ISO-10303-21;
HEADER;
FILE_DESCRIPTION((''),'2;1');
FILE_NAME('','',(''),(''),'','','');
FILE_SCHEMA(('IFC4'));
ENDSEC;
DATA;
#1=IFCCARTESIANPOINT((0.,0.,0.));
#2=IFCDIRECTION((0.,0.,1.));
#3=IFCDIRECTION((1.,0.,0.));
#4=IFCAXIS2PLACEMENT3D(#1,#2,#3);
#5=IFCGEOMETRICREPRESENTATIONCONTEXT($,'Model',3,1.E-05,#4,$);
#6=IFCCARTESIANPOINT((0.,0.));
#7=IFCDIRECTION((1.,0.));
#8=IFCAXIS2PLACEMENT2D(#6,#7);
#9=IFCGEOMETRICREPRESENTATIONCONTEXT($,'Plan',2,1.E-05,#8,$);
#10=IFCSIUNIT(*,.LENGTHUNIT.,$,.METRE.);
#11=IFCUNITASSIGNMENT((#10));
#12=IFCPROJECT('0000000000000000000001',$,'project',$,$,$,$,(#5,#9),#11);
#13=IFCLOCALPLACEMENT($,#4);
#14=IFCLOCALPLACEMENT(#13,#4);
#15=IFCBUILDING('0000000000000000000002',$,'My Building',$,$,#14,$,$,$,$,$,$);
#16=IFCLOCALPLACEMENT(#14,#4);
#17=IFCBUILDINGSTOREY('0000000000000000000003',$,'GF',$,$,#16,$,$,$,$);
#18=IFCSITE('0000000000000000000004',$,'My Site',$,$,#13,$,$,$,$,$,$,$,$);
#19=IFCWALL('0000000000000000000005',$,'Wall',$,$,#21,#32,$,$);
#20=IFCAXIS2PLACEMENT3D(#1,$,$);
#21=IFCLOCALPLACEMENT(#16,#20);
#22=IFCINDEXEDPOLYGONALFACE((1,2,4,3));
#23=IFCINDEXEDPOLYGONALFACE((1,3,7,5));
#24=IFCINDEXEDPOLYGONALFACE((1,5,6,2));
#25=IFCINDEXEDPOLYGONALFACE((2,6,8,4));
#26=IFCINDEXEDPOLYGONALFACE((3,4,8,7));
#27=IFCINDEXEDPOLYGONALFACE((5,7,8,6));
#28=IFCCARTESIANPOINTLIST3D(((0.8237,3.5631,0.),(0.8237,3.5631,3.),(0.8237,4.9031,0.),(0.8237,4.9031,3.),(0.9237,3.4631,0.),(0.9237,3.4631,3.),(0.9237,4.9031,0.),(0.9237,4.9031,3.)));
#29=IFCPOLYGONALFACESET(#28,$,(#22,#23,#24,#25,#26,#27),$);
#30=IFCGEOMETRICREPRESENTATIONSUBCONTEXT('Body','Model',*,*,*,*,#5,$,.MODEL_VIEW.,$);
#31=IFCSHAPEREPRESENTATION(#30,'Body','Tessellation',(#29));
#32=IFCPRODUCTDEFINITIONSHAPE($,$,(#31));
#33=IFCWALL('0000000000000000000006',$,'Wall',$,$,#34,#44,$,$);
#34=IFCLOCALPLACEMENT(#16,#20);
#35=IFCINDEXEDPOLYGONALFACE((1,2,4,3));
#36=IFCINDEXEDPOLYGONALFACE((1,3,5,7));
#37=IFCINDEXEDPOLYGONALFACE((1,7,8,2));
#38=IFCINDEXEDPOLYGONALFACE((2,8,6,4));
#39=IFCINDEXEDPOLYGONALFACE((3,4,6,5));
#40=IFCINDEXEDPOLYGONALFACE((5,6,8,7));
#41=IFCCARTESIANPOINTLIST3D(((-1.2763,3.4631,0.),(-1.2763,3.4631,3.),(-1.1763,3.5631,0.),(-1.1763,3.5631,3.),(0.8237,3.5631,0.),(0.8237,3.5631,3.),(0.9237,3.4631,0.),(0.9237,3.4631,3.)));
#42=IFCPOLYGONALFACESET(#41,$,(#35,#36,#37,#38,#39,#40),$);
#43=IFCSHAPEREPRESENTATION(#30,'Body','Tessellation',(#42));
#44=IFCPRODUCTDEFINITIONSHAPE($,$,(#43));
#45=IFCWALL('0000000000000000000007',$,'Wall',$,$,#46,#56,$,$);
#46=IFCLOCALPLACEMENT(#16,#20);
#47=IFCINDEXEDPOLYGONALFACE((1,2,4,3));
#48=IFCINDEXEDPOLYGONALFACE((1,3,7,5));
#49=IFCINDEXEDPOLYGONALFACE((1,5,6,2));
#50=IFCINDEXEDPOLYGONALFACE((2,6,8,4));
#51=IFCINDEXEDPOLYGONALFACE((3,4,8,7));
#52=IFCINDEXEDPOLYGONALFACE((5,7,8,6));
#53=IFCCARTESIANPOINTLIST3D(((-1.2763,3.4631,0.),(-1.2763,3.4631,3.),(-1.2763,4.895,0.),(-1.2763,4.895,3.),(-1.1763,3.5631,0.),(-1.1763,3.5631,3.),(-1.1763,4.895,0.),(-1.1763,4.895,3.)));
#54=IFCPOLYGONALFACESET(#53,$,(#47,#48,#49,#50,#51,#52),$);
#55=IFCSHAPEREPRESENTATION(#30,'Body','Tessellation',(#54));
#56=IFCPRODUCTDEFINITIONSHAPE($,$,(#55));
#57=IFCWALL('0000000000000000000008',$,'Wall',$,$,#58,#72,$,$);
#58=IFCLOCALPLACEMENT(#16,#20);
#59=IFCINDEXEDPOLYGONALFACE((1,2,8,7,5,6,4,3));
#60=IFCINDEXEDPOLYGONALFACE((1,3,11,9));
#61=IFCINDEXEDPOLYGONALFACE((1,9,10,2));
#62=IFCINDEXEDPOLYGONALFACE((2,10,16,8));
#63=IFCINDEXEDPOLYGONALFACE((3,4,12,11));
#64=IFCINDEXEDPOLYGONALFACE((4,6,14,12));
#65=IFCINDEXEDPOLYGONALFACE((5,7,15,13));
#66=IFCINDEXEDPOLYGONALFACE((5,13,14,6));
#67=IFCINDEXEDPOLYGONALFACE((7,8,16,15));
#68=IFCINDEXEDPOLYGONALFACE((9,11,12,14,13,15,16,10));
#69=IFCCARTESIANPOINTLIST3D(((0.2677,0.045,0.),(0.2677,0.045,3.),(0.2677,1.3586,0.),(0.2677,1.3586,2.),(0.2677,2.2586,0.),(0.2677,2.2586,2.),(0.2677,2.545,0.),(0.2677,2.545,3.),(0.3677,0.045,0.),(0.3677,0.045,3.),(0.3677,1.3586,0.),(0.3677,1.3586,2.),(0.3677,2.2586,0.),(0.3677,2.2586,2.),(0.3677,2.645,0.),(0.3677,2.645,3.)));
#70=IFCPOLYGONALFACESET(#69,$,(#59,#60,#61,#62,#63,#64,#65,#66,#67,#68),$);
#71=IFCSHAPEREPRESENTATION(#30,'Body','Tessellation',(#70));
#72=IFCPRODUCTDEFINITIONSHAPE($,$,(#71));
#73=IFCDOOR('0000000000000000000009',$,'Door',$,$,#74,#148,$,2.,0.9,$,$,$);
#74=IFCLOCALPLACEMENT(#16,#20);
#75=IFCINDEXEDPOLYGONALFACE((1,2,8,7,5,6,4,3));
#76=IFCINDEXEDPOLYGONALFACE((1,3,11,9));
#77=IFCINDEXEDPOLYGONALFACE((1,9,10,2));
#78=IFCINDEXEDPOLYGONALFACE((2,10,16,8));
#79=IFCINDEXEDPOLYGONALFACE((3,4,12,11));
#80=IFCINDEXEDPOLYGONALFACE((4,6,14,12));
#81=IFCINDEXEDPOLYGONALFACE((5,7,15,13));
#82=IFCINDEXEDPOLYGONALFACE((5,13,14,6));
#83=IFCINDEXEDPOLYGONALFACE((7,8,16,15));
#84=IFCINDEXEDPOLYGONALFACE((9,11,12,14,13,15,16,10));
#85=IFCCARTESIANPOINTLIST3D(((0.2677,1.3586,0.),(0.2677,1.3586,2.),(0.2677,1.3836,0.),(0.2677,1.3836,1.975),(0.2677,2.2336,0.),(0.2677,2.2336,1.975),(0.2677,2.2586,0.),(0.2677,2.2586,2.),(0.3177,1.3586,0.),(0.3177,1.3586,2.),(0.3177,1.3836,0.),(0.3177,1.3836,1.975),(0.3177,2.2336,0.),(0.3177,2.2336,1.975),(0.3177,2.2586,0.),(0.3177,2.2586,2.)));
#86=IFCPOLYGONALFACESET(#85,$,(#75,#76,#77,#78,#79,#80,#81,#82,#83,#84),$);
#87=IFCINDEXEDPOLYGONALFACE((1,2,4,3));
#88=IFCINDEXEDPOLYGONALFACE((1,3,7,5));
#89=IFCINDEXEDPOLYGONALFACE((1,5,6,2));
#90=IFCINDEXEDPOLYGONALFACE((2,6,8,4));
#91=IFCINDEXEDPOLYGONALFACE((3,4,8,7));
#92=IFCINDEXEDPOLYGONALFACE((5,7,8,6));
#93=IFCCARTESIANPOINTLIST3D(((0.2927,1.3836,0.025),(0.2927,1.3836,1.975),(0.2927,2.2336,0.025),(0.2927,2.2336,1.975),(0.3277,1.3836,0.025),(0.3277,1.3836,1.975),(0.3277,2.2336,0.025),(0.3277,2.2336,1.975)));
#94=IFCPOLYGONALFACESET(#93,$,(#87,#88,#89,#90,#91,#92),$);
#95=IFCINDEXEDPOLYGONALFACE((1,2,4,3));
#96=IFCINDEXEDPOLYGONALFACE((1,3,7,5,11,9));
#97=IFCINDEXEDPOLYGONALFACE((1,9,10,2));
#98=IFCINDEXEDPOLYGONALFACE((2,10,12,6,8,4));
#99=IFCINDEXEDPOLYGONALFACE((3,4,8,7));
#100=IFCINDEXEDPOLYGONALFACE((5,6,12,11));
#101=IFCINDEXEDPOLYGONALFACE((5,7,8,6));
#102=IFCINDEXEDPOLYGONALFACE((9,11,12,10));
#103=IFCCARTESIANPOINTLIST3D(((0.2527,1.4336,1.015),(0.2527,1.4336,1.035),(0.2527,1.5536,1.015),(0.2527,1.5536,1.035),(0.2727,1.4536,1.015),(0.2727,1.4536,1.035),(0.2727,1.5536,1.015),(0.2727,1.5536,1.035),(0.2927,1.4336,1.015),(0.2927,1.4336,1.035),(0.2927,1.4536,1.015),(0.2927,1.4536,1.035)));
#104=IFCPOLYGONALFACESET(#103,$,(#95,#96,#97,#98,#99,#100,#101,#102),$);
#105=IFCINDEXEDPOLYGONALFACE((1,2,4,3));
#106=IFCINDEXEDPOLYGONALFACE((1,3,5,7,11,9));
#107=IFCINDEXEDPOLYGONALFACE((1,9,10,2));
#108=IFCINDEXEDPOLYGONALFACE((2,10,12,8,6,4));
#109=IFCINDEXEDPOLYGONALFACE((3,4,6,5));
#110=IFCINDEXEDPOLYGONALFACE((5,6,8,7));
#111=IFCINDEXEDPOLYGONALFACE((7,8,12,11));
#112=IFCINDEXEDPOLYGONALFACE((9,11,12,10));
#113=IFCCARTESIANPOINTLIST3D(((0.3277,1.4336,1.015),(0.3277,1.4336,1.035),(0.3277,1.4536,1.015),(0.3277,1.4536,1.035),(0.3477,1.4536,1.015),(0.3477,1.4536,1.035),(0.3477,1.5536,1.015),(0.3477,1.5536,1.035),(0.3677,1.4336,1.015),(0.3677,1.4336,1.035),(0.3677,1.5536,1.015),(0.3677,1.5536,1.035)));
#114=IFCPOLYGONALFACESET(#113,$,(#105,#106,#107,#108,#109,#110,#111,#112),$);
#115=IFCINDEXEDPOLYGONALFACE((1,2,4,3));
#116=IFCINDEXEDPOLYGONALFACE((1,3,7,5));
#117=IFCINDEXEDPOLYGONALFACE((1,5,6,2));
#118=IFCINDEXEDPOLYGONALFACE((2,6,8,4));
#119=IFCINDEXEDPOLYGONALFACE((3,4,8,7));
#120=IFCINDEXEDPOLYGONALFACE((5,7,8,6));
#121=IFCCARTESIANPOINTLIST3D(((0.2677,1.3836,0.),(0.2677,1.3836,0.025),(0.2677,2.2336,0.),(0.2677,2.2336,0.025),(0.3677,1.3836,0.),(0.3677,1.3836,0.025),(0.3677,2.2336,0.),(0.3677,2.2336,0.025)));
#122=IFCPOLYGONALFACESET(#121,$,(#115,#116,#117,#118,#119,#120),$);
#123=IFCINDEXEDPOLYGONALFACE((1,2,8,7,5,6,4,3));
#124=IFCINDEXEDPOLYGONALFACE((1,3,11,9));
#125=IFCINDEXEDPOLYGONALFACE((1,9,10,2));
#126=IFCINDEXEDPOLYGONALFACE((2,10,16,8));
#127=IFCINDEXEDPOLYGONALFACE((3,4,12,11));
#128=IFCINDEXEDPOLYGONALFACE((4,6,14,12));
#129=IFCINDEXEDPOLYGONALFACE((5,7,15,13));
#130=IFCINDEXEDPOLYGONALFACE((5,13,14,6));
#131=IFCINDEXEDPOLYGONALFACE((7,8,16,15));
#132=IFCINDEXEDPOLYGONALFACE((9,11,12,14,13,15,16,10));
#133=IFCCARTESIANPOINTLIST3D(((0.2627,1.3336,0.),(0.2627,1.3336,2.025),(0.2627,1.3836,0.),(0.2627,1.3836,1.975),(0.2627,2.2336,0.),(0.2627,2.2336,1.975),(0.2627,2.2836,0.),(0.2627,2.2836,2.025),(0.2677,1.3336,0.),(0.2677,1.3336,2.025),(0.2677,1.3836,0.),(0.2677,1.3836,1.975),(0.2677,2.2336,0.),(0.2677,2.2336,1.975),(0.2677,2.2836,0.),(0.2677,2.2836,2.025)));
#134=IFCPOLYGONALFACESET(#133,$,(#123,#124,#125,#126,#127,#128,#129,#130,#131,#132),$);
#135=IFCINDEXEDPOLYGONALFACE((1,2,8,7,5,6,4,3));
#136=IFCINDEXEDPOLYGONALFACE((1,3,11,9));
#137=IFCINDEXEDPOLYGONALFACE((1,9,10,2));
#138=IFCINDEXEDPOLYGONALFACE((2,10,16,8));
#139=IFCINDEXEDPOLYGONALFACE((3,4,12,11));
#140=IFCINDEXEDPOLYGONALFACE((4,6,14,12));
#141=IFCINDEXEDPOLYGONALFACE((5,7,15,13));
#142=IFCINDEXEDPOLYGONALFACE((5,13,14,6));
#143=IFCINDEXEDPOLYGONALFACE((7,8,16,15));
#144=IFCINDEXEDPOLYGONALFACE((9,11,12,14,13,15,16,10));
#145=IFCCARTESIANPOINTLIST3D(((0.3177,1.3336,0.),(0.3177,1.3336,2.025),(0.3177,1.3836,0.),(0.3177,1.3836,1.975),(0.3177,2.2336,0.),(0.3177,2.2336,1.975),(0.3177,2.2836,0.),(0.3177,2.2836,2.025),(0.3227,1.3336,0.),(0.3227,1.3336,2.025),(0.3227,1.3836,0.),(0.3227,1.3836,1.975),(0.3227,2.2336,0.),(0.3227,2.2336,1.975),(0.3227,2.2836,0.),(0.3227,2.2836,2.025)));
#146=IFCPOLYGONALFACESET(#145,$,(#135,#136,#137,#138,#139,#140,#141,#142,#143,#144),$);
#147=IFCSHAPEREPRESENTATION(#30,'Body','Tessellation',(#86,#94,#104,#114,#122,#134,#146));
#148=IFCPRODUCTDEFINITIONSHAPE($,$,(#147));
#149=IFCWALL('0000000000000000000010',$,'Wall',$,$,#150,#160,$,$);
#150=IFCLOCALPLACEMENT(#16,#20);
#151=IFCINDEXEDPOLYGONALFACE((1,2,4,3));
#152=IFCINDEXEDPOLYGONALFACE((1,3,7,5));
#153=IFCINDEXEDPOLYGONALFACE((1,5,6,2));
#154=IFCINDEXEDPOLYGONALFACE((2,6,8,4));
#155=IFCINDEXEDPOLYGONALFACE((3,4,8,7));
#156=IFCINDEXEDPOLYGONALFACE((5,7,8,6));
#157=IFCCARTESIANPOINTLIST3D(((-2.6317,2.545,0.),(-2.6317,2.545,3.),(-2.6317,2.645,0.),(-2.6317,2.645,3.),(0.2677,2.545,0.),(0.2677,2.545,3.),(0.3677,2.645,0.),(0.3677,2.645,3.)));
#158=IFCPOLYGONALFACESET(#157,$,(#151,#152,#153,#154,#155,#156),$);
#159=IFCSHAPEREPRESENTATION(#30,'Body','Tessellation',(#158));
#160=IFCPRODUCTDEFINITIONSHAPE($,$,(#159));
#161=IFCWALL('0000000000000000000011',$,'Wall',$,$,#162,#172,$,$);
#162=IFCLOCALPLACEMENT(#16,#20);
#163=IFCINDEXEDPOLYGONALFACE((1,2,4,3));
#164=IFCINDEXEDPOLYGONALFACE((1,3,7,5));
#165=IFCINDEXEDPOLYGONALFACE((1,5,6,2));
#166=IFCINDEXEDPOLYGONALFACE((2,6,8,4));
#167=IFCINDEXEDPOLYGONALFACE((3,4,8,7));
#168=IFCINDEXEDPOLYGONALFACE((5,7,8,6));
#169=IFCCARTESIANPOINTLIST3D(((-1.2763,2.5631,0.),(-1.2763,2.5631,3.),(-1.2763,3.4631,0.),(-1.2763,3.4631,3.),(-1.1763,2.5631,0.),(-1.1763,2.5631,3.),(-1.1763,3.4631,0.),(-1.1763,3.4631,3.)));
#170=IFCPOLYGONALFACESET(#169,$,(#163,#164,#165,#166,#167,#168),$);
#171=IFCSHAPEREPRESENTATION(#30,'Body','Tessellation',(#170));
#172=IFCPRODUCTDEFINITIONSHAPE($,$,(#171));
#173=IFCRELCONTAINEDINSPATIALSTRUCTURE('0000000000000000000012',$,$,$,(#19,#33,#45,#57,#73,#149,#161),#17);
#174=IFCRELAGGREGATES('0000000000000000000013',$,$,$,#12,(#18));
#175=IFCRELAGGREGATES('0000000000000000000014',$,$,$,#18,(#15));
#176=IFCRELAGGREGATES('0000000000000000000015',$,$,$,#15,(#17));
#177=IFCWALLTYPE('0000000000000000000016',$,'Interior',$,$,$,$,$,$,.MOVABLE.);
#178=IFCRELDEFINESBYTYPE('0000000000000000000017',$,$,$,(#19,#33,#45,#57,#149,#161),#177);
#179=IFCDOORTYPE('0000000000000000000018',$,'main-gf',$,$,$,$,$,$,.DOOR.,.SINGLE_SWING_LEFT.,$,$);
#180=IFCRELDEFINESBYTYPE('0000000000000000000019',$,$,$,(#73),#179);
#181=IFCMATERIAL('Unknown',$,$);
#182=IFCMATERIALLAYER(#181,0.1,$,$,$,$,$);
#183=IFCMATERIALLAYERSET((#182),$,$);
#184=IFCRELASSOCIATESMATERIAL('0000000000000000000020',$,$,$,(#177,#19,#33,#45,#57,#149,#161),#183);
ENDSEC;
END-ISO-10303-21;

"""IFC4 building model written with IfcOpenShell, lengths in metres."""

from ifc_helpers import new_model, entity, si_unit, frame, origin_with_axes, origin_2d_with_axis, place, context, subcontext, project, spatial, line, indexed_curve, outline, extrude, shape, source, transform, mapped, material, layer, layer_set, layer_usage, type_object, type_shapes, element, fill, save


model = new_model("IFC4")

# Units and contexts
model_context = context("Model", 3, precision=1e-05, world=origin_with_axes())
plan_context = context("Plan", 2, precision=1e-05, world=origin_2d_with_axis())
body_context_1 = subcontext(model_context, "Body", "Model", "MODEL_VIEW")
body_context_2 = subcontext(plan_context, "Body", "Plan", "PLAN_VIEW")
ifc_project = project(units=[si_unit("LENGTHUNIT", "METRE")], contexts=[model_context, plan_context])

# Site, building, storey
site_placement = place(None, origin_with_axes())
site = spatial("IfcSite", under=ifc_project, at=site_placement, Name="My Site")
building_placement = place(site_placement, origin_with_axes())
building = spatial("IfcBuilding", under=site, at=building_placement, Name="My Building")
storey_placement = place(building_placement, origin_with_axes())
storey = spatial("IfcBuildingStorey", under=building, at=storey_placement, Name="GF")

# Shared definitions
ifc_material = material(Name="Unknown")

# Shared definitions
shared_shape_1 = source(origin_with_axes(), body_context_1, "Body", "SweptSolid", [
    extrude(outline(indexed_curve([(0.0, 0.0), (0.9, 0.0), (0.9, 2.0), (0.0, 2.0)], segments=[line(1, 2, 3, 4, 1)])), frame((0.0, -0.6, 0.0), z_axis=(0.0, -1.0, 0.0), x_axis=(1.0, 0.0, 0.0)), (0.0, 0.0, -1.0), 1.2),
])
door_type = type_object("IfcDoorType", Name="main-gf", OperationType="SINGLE_SWING_LEFT", PredefinedType="DOOR")
shared_shape_2 = source(origin_with_axes(), body_context_1, "Body", "SweptSolid", [
    extrude(outline(indexed_curve([(0.0, 0.0), (0.0, 2.0), (0.9, 2.0), (0.9, 0.0), (0.875, 0.0), (0.875, 1.975), (0.025, 1.975), (0.025, 0.0)], segments=[line(1, 2, 3, 4, 5, 6, 7, 8, 1)])), frame((0.0, 0.0, 0.0), z_axis=(0.0, -1.0, 0.0), x_axis=(1.0, 0.0, 0.0)), (0.0, 0.0, -1.0), 0.05),
    extrude(outline(indexed_curve([(0.0, 0.0), (0.85, 0.0), (0.85, 0.035), (0.0, 0.035)], segments=[line(1, 2, 3, 4, 1)])), frame((0.025, 0.025, 0.025), z_axis=(0.0, 0.0, 1.0), x_axis=(1.0, 0.0, 0.0)), (0.0, 0.0, 1.0), 1.95),
    extrude(outline(indexed_curve([(0.0, 0.0), (0.0, -0.04), (-0.12, -0.04), (-0.12, -0.02), (-0.02, -0.02), (-0.02, 0.0)], segments=[line(1, 2, 3, 4, 5, 6, 1)])), frame((0.825, 0.025, 1.015), z_axis=(0.0, 0.0, 1.0), x_axis=(1.0, 0.0, 0.0)), (0.0, 0.0, 1.0), 0.02),
    extrude(outline(indexed_curve([(0.0, 0.0), (0.0, 0.04), (-0.12, 0.04), (-0.12, 0.02), (-0.02, 0.02), (-0.02, 0.0)], segments=[line(1, 2, 3, 4, 5, 6, 1)])), frame((0.825, 0.06, 1.015), z_axis=(0.0, 0.0, 1.0), x_axis=(1.0, 0.0, 0.0)), (0.0, 0.0, 1.0), 0.02),
    extrude(outline(indexed_curve([(0.0, 0.0), (0.85, 0.0), (0.85, 0.1), (0.0, 0.1)], segments=[line(1, 2, 3, 4, 1)])), frame((0.025, 0.0, 0.0), z_axis=(0.0, 0.0, 1.0), x_axis=(1.0, 0.0, 0.0)), (0.0, 0.0, 1.0), 0.025),
    extrude(outline(indexed_curve([(0.0, 0.0), (0.0, 2.025), (0.95, 2.025), (0.95, 0.0), (0.9, 0.0), (0.9, 1.975), (0.05, 1.975), (0.05, 0.0)], segments=[line(1, 2, 3, 4, 5, 6, 7, 8, 1)])), frame((-0.025, -0.005, 0.0), z_axis=(0.0, -1.0, 0.0), x_axis=(1.0, 0.0, 0.0)), (0.0, 0.0, -1.0), 0.005),
    extrude(outline(indexed_curve([(0.0, 0.0), (0.0, 2.025), (0.95, 2.025), (0.95, 0.0), (0.9, 0.0), (0.9, 1.975), (0.05, 1.975), (0.05, 0.0)], segments=[line(1, 2, 3, 4, 5, 6, 7, 8, 1)])), frame((-0.025, 0.05, 0.0), z_axis=(0.0, -1.0, 0.0), x_axis=(1.0, 0.0, 0.0)), (0.0, 0.0, -1.0), 0.005),
])
shared_shape_3 = source(origin_with_axes(), body_context_2, "Body", "Curve2D", [
    entity("IfcIndexedPolyCurve", entity("IfcCartesianPointList2D", [[0.0, 0.0], [0.025, 0.0], [0.025, 0.05], [0.0, 0.05]]), [entity("IfcLineIndex", [1, 2, 3, 4, 1])]),
    entity("IfcIndexedPolyCurve", entity("IfcCartesianPointList2D", [[0.9, 0.0], [0.875, 0.0], [0.875, 0.05], [0.9, 0.05]]), [entity("IfcLineIndex", [1, 2, 3, 4, 1])]),
    entity("IfcIndexedPolyCurve", entity("IfcCartesianPointList2D", [[0.025, 0.05], [0.025, -0.8], [0.06, -0.8]])),
    entity("IfcTrimmedCurve", entity("IfcEllipse", entity("IfcAxis2Placement2D", entity("IfcCartesianPoint", [0.06, 0.05]), entity("IfcDirection", [1.0, 0.0])), 0.815, 0.85), [entity("IfcCartesianPoint", [0.06, -0.8])], [entity("IfcCartesianPoint", [0.06, 0.9])], True, "CARTESIAN"),
    entity("IfcIndexedPolyCurve", entity("IfcCartesianPointList2D", [[0.025, 0.05], [0.06, 0.05], [0.06, 0.9], [0.025, 0.9]]), [entity("IfcLineIndex", [1, 2, 3, 4, 1])]),
])
type_shapes(door_type, [shared_shape_2, shared_shape_3])

# Walls
ifc_layer_1 = layer(ifc_material, 0.1)
ifc_layer_set_1 = layer_set([ifc_layer_1])
ifc_layer_usage_1 = layer_usage(ifc_layer_set_1, "AXIS2", "POSITIVE", 0.0)
wall_type_1 = type_object("IfcWallType", Name="Interior", PredefinedType="MOVABLE", material=ifc_layer_set_1)
wall_1_placement = place(storey_placement, frame((0.8237, 4.9031, 0.0), z_axis=(0.0, 0.0, 1.0), x_axis=(0.0, -1.0, 0.0)))
element("IfcWall", 1, at=wall_1_placement, inside=storey, type_object=wall_type_1, material=ifc_layer_usage_1, Name="Wall", context=body_context_1, shape_type="SweptSolid", body=[
    extrude(outline(indexed_curve([(0.0, 0.0), (0.0, 0.1), (1.44, 0.1), (1.34, 0.0)], segments=[line(1, 2, 3, 4, 1)])), origin_with_axes(), (0.0, 0.0, 1.0), 3.0),
])
ifc_layer_usage_2 = layer_usage(ifc_layer_set_1, "AXIS2", "POSITIVE", 0.0)
wall_2_placement = place(storey_placement, frame((0.8237, 3.5631, 0.0), z_axis=(0.0, 0.0, 1.0), x_axis=(-1.0, 0.0, 0.0)))
element("IfcWall", 2, at=wall_2_placement, inside=storey, type_object=wall_type_1, material=ifc_layer_usage_2, Name="Wall", context=body_context_1, shape_type="SweptSolid", body=[
    extrude(outline(indexed_curve([(0.0, 0.0), (-0.1, 0.1), (2.1, 0.1), (2.0, 0.0)], segments=[line(1, 2, 3, 4, 1)])), origin_with_axes(), (0.0, 0.0, 1.0), 3.0),
])
ifc_layer_usage_3 = layer_usage(ifc_layer_set_1, "AXIS2", "POSITIVE", 0.0)
wall_3_placement = place(storey_placement, frame((-1.1763, 3.5631, 0.0), z_axis=(0.0, 0.0, 1.0), x_axis=(0.0, 1.0, 0.0)))
element("IfcWall", 3, at=wall_3_placement, inside=storey, type_object=wall_type_1, material=ifc_layer_usage_3, Name="Wall", context=body_context_1, shape_type="SweptSolid", body=[
    extrude(outline(indexed_curve([(0.0, 0.0), (-0.1, 0.1), (1.3318, 0.1), (1.3318, 0.0)], segments=[line(1, 2, 3, 4, 1)])), origin_with_axes(), (0.0, 0.0, 1.0), 3.0),
])

# Wall, opening, door
ifc_layer_usage_4 = layer_usage(ifc_layer_set_1, "AXIS2", "POSITIVE", 0.0)
wall_4_placement = place(storey_placement, frame((0.3677, 0.045, 0.0), z_axis=(0.0, 0.0, 1.0), x_axis=(0.0, 1.0, 0.0)))
wall_4 = element("IfcWall", 4, at=wall_4_placement, inside=storey, type_object=wall_type_1, material=ifc_layer_usage_4, Name="Wall", context=body_context_1, shape_type="SweptSolid", body=[
    extrude(outline(indexed_curve([(0.0, 0.0), (0.0, 0.1), (2.5, 0.1), (2.6, 0.0)], segments=[line(1, 2, 3, 4, 1)])), origin_with_axes(), (0.0, 0.0, 1.0), 3.0),
])
opening_1_placement = place(wall_4_placement, frame((2.2136, 0.1, 0.0), z_axis=(0.0, 0.0, 1.0), x_axis=(-1.0, 0.0, 0.0)))
opening_1 = element("IfcOpeningElement", 5, at=opening_1_placement, cuts=wall_4, PredefinedType="OPENING", context=body_context_1, shape_type="MappedRepresentation", body=[
    mapped(shared_shape_1, transform((0.0, 0.0, 0.0), x_axis=(1.0, 0.0, 0.0), y_axis=(0.0, 1.0, 0.0), z_axis=(0.0, 0.0, 1.0), scale=1.0)),
])
door_1_placement = place(opening_1_placement, frame((0.0, 0.0, 0.0), z_axis=(0.0, 0.0, 1.0), x_axis=(1.0, 0.0, 0.0)))
door_1 = element("IfcDoor", 6, at=door_1_placement, inside=storey, type_object=door_type, Name="Door", OverallHeight=2.0, OverallWidth=0.9, shapes=[
    shape(body_context_1, "Body", "MappedRepresentation", [mapped(shared_shape_2, transform((0.0, 0.0, 0.0), x_axis=(1.0, 0.0, 0.0), y_axis=(0.0, 1.0, 0.0), z_axis=(0.0, 0.0, 1.0), scale=1.0))]),
    shape(body_context_2, "Body", "MappedRepresentation", [mapped(shared_shape_3, transform((0.0, 0.0, 0.0), x_axis=(1.0, 0.0, 0.0), y_axis=(0.0, 1.0, 0.0), z_axis=(0.0, 0.0, 1.0), scale=1.0))]),
])
fill(opening_1, door_1)

# Walls
ifc_layer_usage_5 = layer_usage(ifc_layer_set_1, "AXIS2", "POSITIVE", 0.0)
wall_5_placement = place(storey_placement, frame((0.3677, 2.645, 0.0), z_axis=(0.0, 0.0, 1.0), x_axis=(-1.0, 0.0, 0.0)))
element("IfcWall", 7, at=wall_5_placement, inside=storey, type_object=wall_type_1, material=ifc_layer_usage_5, Name="Wall", context=body_context_1, shape_type="SweptSolid", body=[
    extrude(outline(indexed_curve([(0.0, 0.0), (0.1, 0.1), (2.9994, 0.1), (2.9994, 0.0)], segments=[line(1, 2, 3, 4, 1)])), origin_with_axes(), (0.0, 0.0, 1.0), 3.0),
])
ifc_layer_usage_6 = layer_usage(ifc_layer_set_1, "AXIS2", "POSITIVE", 0.0)
wall_6_placement = place(storey_placement, frame((-1.2763, 3.4631, 0.0), z_axis=(0.0, 0.0, 1.0), x_axis=(0.0, -1.0, 0.0)))
element("IfcWall", 8, at=wall_6_placement, inside=storey, type_object=wall_type_1, material=ifc_layer_usage_6, Name="Wall", context=body_context_1, shape_type="SweptSolid", body=[
    extrude(outline(indexed_curve([(0.0, 0.0), (0.0, 0.1), (0.9, 0.1), (0.9, 0.0)], segments=[line(1, 2, 3, 4, 1)])), origin_with_axes(), (0.0, 0.0, 1.0), 3.0),
])

save(model, "model.ifc")
